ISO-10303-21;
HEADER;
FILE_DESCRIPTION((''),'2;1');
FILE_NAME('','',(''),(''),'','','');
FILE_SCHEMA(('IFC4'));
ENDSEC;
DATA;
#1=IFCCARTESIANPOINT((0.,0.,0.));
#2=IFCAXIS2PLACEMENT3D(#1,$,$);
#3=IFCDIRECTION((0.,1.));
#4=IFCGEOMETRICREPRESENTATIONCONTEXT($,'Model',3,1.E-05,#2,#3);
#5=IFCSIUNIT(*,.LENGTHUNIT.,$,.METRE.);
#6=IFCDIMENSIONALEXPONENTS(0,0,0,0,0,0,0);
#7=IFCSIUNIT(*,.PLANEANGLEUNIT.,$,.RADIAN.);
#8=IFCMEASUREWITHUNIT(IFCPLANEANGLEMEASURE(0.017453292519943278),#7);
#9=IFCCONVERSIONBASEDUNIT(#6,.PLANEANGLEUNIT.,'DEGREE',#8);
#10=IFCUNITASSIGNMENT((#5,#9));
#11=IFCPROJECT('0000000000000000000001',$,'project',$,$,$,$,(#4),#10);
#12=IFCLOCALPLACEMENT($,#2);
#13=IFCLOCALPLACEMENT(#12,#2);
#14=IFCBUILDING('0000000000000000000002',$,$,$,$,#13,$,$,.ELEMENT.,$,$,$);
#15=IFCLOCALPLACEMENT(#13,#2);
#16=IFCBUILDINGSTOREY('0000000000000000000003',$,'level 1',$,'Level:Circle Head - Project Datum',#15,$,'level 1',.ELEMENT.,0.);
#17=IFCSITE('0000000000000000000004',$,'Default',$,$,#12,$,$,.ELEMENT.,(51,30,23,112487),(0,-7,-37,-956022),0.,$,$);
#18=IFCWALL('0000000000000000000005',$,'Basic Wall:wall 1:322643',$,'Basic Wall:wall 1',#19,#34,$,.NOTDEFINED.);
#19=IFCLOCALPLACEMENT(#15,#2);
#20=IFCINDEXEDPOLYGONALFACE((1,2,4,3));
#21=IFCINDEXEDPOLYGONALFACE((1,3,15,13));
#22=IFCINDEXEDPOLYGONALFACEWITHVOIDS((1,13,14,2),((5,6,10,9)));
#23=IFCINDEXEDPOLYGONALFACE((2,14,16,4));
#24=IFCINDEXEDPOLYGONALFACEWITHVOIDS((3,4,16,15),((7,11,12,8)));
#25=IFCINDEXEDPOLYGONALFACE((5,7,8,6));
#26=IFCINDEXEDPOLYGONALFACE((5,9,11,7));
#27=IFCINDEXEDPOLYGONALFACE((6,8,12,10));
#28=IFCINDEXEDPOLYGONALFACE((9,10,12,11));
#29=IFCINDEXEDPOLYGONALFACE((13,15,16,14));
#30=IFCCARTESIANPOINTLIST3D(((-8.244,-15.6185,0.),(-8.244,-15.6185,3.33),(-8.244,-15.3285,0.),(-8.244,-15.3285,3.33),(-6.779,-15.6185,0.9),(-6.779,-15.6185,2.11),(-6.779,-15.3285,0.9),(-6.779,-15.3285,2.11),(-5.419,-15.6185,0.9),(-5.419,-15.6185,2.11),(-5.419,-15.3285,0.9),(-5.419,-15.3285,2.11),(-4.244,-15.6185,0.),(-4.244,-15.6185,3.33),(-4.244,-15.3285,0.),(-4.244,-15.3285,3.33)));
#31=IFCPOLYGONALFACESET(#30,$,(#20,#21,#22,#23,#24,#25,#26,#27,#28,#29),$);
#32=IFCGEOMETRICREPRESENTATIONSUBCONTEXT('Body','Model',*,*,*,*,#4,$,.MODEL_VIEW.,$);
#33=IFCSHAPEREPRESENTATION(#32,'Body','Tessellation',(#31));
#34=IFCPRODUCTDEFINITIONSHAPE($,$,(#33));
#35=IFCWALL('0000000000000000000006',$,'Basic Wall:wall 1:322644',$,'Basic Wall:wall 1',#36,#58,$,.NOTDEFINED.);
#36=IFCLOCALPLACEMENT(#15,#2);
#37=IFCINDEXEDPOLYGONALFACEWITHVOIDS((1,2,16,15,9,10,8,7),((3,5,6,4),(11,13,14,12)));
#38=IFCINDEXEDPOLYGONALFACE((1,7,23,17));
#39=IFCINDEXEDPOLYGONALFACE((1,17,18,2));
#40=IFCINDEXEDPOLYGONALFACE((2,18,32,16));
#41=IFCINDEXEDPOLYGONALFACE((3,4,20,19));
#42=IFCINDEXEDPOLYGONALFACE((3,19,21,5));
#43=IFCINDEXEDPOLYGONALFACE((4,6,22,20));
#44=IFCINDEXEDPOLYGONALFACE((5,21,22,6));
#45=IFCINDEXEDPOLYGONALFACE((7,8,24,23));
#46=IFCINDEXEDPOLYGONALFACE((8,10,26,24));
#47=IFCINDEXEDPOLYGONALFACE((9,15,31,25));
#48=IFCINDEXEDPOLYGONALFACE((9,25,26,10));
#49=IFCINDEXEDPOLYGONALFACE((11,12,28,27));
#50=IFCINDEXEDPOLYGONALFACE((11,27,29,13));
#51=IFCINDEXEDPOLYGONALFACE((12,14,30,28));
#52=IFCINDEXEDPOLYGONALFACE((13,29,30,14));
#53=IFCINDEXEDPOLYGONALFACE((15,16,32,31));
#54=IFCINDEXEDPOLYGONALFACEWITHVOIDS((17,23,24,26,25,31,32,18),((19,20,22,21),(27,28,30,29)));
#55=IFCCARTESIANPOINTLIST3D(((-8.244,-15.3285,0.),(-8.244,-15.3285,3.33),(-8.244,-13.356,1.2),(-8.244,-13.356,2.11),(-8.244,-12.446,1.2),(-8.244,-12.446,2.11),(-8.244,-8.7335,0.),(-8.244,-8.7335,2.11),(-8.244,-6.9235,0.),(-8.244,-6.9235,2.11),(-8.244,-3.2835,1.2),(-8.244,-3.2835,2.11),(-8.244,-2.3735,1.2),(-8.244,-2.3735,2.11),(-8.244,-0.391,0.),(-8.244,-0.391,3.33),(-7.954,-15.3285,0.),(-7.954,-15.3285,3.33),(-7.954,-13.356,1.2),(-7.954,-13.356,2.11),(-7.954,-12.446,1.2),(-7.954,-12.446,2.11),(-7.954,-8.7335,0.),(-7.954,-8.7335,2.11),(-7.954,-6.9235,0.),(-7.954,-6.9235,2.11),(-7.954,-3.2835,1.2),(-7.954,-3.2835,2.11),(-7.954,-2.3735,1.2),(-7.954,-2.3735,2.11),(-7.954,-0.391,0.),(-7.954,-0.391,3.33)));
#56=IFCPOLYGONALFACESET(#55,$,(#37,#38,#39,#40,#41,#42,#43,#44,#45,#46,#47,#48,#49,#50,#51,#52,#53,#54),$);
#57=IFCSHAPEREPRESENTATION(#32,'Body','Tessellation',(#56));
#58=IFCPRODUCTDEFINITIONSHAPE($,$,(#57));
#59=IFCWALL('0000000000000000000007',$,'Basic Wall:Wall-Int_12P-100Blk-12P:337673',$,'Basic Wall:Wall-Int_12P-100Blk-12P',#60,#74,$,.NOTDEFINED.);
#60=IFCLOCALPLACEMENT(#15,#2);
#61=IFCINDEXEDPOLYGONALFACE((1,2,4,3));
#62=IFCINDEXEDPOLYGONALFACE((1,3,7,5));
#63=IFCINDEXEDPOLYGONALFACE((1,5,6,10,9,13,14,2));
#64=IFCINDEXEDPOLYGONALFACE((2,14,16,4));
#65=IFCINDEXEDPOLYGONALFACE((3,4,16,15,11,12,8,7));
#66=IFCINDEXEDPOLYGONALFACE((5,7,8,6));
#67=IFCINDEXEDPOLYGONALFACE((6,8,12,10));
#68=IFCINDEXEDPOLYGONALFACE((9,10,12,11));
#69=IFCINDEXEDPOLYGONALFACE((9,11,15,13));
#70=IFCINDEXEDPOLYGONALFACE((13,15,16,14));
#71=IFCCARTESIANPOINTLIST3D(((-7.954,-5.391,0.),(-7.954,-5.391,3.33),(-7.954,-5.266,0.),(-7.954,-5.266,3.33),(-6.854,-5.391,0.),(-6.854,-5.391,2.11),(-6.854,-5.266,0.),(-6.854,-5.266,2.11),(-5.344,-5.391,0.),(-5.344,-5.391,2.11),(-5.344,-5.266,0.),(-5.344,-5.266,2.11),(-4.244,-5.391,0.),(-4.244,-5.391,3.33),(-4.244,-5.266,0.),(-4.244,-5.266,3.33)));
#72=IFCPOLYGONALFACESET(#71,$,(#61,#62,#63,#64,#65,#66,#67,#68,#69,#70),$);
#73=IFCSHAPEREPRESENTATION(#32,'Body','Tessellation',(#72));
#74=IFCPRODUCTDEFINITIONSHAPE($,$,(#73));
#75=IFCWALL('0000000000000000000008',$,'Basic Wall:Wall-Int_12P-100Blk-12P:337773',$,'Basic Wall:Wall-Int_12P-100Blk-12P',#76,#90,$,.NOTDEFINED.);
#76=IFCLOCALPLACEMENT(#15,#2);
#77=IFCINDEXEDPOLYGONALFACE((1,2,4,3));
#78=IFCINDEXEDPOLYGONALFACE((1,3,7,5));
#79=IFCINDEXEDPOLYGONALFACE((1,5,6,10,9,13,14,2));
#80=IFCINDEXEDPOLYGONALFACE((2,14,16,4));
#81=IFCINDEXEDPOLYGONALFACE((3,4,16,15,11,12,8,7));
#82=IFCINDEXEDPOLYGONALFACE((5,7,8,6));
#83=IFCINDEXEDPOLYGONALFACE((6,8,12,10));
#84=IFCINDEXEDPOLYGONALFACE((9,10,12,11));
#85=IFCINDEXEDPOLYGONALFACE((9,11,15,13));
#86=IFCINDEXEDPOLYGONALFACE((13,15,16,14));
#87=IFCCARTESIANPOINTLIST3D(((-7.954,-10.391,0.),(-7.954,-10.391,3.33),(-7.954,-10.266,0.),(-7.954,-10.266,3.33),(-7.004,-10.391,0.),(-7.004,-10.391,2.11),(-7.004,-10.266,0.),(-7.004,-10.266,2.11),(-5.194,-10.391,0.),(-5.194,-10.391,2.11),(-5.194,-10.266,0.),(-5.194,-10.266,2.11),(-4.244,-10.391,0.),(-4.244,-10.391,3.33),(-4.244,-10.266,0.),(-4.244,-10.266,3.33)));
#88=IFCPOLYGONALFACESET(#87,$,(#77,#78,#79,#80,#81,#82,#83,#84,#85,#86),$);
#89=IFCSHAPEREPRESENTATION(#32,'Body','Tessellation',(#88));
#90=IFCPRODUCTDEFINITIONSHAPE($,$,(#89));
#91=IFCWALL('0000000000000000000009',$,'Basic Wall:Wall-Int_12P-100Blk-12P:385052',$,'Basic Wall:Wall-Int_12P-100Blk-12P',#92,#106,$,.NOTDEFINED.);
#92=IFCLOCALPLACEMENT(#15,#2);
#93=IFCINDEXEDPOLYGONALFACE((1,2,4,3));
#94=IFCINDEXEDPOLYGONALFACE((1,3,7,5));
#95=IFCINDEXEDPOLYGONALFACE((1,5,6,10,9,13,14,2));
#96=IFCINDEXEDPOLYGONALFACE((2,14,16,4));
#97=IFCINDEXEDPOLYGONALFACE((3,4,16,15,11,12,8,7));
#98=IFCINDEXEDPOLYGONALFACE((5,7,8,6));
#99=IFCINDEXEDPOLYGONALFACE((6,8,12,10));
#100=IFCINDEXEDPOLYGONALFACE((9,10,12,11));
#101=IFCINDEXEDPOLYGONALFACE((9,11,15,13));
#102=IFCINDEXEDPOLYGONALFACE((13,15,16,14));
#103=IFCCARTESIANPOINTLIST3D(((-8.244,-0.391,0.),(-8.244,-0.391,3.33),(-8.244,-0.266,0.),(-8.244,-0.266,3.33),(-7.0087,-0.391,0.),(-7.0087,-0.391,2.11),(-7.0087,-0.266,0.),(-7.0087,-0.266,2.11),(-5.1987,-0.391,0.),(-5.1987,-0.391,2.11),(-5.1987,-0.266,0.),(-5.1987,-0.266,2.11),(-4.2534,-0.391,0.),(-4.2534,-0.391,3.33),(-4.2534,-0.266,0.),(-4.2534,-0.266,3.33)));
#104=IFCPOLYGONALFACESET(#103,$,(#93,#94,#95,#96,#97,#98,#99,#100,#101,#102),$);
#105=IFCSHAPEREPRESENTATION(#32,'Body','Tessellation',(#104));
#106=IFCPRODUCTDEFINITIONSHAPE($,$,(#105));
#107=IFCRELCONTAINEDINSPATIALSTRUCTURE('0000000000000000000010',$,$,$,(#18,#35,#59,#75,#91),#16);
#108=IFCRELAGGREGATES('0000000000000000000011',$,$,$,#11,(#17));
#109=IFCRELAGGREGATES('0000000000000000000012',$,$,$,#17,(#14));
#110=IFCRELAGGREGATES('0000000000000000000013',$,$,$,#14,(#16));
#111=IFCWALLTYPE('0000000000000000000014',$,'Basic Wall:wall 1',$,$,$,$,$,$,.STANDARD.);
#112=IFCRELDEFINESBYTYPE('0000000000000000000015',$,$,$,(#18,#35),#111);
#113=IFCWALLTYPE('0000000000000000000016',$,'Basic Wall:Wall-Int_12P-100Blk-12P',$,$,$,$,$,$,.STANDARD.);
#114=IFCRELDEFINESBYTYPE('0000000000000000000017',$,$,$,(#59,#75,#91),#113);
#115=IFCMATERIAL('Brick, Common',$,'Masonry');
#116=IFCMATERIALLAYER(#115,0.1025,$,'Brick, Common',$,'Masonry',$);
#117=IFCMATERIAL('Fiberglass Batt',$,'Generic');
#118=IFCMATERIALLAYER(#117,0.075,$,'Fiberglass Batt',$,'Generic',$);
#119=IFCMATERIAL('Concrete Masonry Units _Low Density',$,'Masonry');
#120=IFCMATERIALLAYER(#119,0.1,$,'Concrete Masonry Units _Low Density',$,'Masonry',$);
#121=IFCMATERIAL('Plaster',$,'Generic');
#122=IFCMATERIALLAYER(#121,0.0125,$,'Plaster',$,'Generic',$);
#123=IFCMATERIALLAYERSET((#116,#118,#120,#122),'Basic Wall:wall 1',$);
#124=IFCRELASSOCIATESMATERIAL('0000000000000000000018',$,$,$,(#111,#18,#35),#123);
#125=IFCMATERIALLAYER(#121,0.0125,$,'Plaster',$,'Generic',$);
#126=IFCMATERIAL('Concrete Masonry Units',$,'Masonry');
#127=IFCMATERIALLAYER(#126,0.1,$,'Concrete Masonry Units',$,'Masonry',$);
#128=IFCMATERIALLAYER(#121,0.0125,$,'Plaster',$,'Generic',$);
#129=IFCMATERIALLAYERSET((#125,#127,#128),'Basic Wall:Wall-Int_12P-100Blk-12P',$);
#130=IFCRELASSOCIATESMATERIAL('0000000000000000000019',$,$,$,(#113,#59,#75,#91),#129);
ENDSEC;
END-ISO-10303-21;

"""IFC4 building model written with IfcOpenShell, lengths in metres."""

from ifc_helpers import new_model, entity, si_unit, converted_unit, direction, frame, frame_2d, origin, place, context, subcontext, project, spatial, polyline, rectangle, extrude, clip, bounded_halfspace, material, layer, layer_set, layer_usage, type_object, element, save


model = new_model("IFC4")

# Units and contexts
model_context = context("Model", 3, precision=1e-05, world=origin(), true_north=direction((0.0, 1.0)))
body_context = subcontext(model_context, "Body", "Model", "MODEL_VIEW")
ifc_project = project(units=[si_unit("LENGTHUNIT", "METRE"), converted_unit("PLANEANGLEUNIT", "DEGREE", entity("IfcPlaneAngleMeasure", 0.017453292519943278), si_unit("PLANEANGLEUNIT", "RADIAN"), dimensions=[0, 0, 0, 0, 0, 0, 0])], contexts=[model_context])

# Site, building, storey
site_placement = place(None, origin())
site = spatial("IfcSite", under=ifc_project, at=site_placement, Name="Default", CompositionType="ELEMENT", RefLatitude=(51, 30, 23, 112487), RefLongitude=(0, -7, -37, -956022), RefElevation=0.0)
building_placement = place(site_placement, origin())
building = spatial("IfcBuilding", under=site, at=building_placement, CompositionType="ELEMENT")
storey_placement = place(building_placement, origin())
storey = spatial("IfcBuildingStorey", under=building, at=storey_placement, Name="level 1", ObjectType="Level:Circle Head - Project Datum", LongName="level 1", CompositionType="ELEMENT", Elevation=0.0)

# Shared definitions
ifc_material_1 = material(Name="Brick, Common", Category="Masonry")
ifc_layer_1 = layer(ifc_material_1, 0.1025, Name="Brick, Common", Category="Masonry")
ifc_material_2 = material(Name="Fiberglass Batt", Category="Generic")
ifc_layer_2 = layer(ifc_material_2, 0.075, Name="Fiberglass Batt", Category="Generic")
ifc_material_3 = material(Name="Concrete Masonry Units _Low Density", Category="Masonry")
ifc_layer_3 = layer(ifc_material_3, 0.1, Name="Concrete Masonry Units _Low Density", Category="Masonry")
ifc_material_4 = material(Name="Plaster", Category="Generic")
ifc_layer_4 = layer(ifc_material_4, 0.0125, Name="Plaster", Category="Generic")
ifc_layer_set_1 = layer_set([ifc_layer_1, ifc_layer_2, ifc_layer_3, ifc_layer_4], Name="Basic Wall:wall 1")
wall_type_1 = type_object("IfcWallType", Name="Basic Wall:wall 1", PredefinedType="STANDARD", material=ifc_layer_set_1)

# Wall, opening
ifc_layer_usage_1 = layer_usage(ifc_layer_set_1, "AXIS2", "NEGATIVE", 0.145)
wall_1_placement = place(storey_placement, frame((-4.244, -15.4735, 0.0), z_axis=(0.0, 0.0, 1.0), x_axis=(-1.0, 0.0, 0.0)))
wall_1 = element("IfcWall", 1, at=wall_1_placement, inside=storey, type_object=wall_type_1, material=ifc_layer_usage_1, Name="Basic Wall:wall 1:322643", ObjectType="Basic Wall:wall 1", PredefinedType="NOTDEFINED", context=body_context, shape_type="Clipping", body=[
    clip(extrude(rectangle(XDim=4.0, YDim=0.29, at=frame_2d((2.0, 0.0), x_axis=(-1.0, 0.0))), origin(), (0.0, 0.0, 1.0), 3.33), bounded_halfspace(frame((0.0, -0.145, 3.33), z_axis=(0.0, 0.0, -1.0), x_axis=(0.0, -1.0, 0.0)), True, frame((0.0, -0.145, 3.33)), polyline([(0.0, 0.0), (3.71, 0.0), (4.0, 0.0), (4.0, 0.29), (0.0, 0.29), (0.0, 0.0)]))),
])
opening_1_placement = place(wall_1_placement, frame((1.175, -0.145, 0.9)))
element("IfcOpeningElement", 2, at=opening_1_placement, cuts=wall_1, PredefinedType="OPENING", context=body_context, shape_type="SweptSolid", body=[
    extrude(rectangle(XDim=1.21, YDim=1.36, at=frame_2d((0.605, 0.68), x_axis=(-1.0, 0.0))), frame((0.0, 0.0, 0.0), z_axis=(0.0, 1.0, 0.0), x_axis=(0.0, 0.0, 1.0)), (0.0, 0.0, 1.0), 0.29),
])

# Wall, openings
ifc_layer_usage_2 = layer_usage(ifc_layer_set_1, "AXIS2", "NEGATIVE", 0.145)
wall_2_placement = place(storey_placement, frame((-8.099, -15.3285, 0.0), z_axis=(0.0, 0.0, 1.0), x_axis=(0.0, 1.0, 0.0)))
wall_2 = element("IfcWall", 3, at=wall_2_placement, inside=storey, type_object=wall_type_1, material=ifc_layer_usage_2, Name="Basic Wall:wall 1:322644", ObjectType="Basic Wall:wall 1", PredefinedType="NOTDEFINED", context=body_context, shape_type="Clipping", body=[
    clip(extrude(rectangle(XDim=14.9375, YDim=0.29, at=frame_2d((7.4688, 0.0), x_axis=(1.0, 0.0))), origin(), (0.0, 0.0, 1.0), 3.33), bounded_halfspace(frame((0.0, -0.145, 3.33), z_axis=(0.0, 0.0, -1.0), x_axis=(1.0, 0.0, 0.0)), True, frame((0.0, -0.145, 3.33)), polyline([(0.0, 0.0), (4.9375, 0.0), (5.0625, 0.0), (9.9375, 0.0), (10.0625, 0.0), (14.9375, 0.0), (14.9375, 0.29), (0.0, 0.29), (0.0, 0.0)]))),
])
opening_2_placement = place(wall_2_placement, frame((8.405, 0.145, 0.0)))
element("IfcOpeningElement", 4, at=opening_2_placement, cuts=wall_2, PredefinedType="OPENING", context=body_context, shape_type="SweptSolid", body=[
    extrude(rectangle(XDim=2.11, YDim=1.81, at=frame_2d((1.055, 0.905), x_axis=(-1.0, 0.0))), frame((0.0, 0.0, 0.0), z_axis=(0.0, -1.0, 0.0), x_axis=(0.0, 0.0, 1.0)), (0.0, 0.0, 1.0), 0.29),
])
opening_3_placement = place(wall_2_placement, frame((1.9725, -0.145, 1.2)))
element("IfcOpeningElement", 5, at=opening_3_placement, cuts=wall_2, PredefinedType="OPENING", context=body_context, shape_type="SweptSolid", body=[
    extrude(rectangle(XDim=0.91, YDim=0.91, at=frame_2d((0.455, 0.455), x_axis=(-1.0, 0.0))), frame((0.0, 0.0, 0.0), z_axis=(0.0, 1.0, 0.0), x_axis=(0.0, 0.0, 1.0)), (0.0, 0.0, 1.0), 0.29),
])
opening_4_placement = place(wall_2_placement, frame((12.045, -0.145, 1.2)))
element("IfcOpeningElement", 6, at=opening_4_placement, cuts=wall_2, PredefinedType="OPENING", context=body_context, shape_type="SweptSolid", body=[
    extrude(rectangle(XDim=0.91, YDim=0.91, at=frame_2d((0.455, 0.455), x_axis=(-1.0, 0.0))), frame((0.0, 0.0, 0.0), z_axis=(0.0, 1.0, 0.0), x_axis=(0.0, 0.0, 1.0)), (0.0, 0.0, 1.0), 0.29),
])

# Walls, openings
ifc_layer_5 = layer(ifc_material_4, 0.0125, Name="Plaster", Category="Generic")
ifc_material_5 = material(Name="Concrete Masonry Units", Category="Masonry")
ifc_layer_6 = layer(ifc_material_5, 0.1, Name="Concrete Masonry Units", Category="Masonry")
ifc_layer_7 = layer(ifc_material_4, 0.0125, Name="Plaster", Category="Generic")
ifc_layer_set_2 = layer_set([ifc_layer_5, ifc_layer_6, ifc_layer_7], Name="Basic Wall:Wall-Int_12P-100Blk-12P")
ifc_layer_usage_3 = layer_usage(ifc_layer_set_2, "AXIS2", "NEGATIVE", 0.0625)
wall_type_2 = type_object("IfcWallType", Name="Basic Wall:Wall-Int_12P-100Blk-12P", PredefinedType="STANDARD", material=ifc_layer_set_2)
wall_3_placement = place(storey_placement, frame((-7.954, -5.3285, 0.0)))
wall_3 = element("IfcWall", 7, at=wall_3_placement, inside=storey, type_object=wall_type_2, material=ifc_layer_usage_3, Name="Basic Wall:Wall-Int_12P-100Blk-12P:337673", ObjectType="Basic Wall:Wall-Int_12P-100Blk-12P", PredefinedType="NOTDEFINED", context=body_context, shape_type="Clipping", body=[
    clip(extrude(rectangle(XDim=3.71, YDim=0.125, at=frame_2d((1.855, 0.0), x_axis=(1.0, 0.0))), origin(), (0.0, 0.0, 1.0), 3.33), bounded_halfspace(frame((0.0, -0.0625, 3.33), z_axis=(0.0, 0.0, -1.0), x_axis=(0.0, 1.0, 0.0)), True, frame((0.0, -0.0625, 3.33)), polyline([(0.0, 0.0), (3.71, 0.0), (3.71, 0.125), (0.0, 0.125), (0.0, 0.0)]))),
])
opening_5_placement = place(wall_3_placement, frame((1.1, -0.0625, 0.0)))
element("IfcOpeningElement", 8, at=opening_5_placement, cuts=wall_3, PredefinedType="OPENING", context=body_context, shape_type="SweptSolid", body=[
    extrude(rectangle(XDim=2.11, YDim=1.51, at=frame_2d((1.055, 0.755), x_axis=(-1.0, 0.0))), frame((0.0, 0.0, 0.0), z_axis=(0.0, 1.0, 0.0), x_axis=(0.0, 0.0, 1.0)), (0.0, 0.0, 1.0), 0.125),
])
ifc_layer_usage_4 = layer_usage(ifc_layer_set_2, "AXIS2", "NEGATIVE", 0.0625)
wall_4_placement = place(storey_placement, frame((-7.954, -10.3285, 0.0)))
wall_4 = element("IfcWall", 9, at=wall_4_placement, inside=storey, type_object=wall_type_2, material=ifc_layer_usage_4, Name="Basic Wall:Wall-Int_12P-100Blk-12P:337773", ObjectType="Basic Wall:Wall-Int_12P-100Blk-12P", PredefinedType="NOTDEFINED", context=body_context, shape_type="Clipping", body=[
    clip(extrude(rectangle(XDim=3.71, YDim=0.125, at=frame_2d((1.855, 0.0), x_axis=(-1.0, 0.0))), origin(), (0.0, 0.0, 1.0), 3.33), bounded_halfspace(frame((0.0, -0.0625, 3.33), z_axis=(0.0, 0.0, -1.0), x_axis=(0.0, 1.0, 0.0)), True, frame((0.0, -0.0625, 3.33)), polyline([(0.0, 0.0), (3.71, 0.0), (3.71, 0.125), (0.0, 0.125), (0.0, 0.0)]))),
])
opening_6_placement = place(wall_4_placement, frame((0.95, -0.0625, 0.0)))
element("IfcOpeningElement", 10, at=opening_6_placement, cuts=wall_4, PredefinedType="OPENING", context=body_context, shape_type="SweptSolid", body=[
    extrude(rectangle(XDim=2.11, YDim=1.81, at=frame_2d((1.055, 0.905), x_axis=(-1.0, 0.0))), frame((0.0, 0.0, 0.0), z_axis=(0.0, 1.0, 0.0), x_axis=(0.0, 0.0, 1.0)), (0.0, 0.0, 1.0), 0.125),
])

# Wall, openings
ifc_layer_usage_5 = layer_usage(ifc_layer_set_2, "AXIS2", "NEGATIVE", 0.0625)
wall_5_placement = place(storey_placement, frame((-4.2534, -0.3285, 0.0), z_axis=(0.0, 0.0, 1.0), x_axis=(-1.0, 0.0, 0.0)))
wall_5 = element("IfcWall", 11, at=wall_5_placement, inside=storey, type_object=wall_type_2, material=ifc_layer_usage_5, Name="Basic Wall:Wall-Int_12P-100Blk-12P:385052", ObjectType="Basic Wall:Wall-Int_12P-100Blk-12P", PredefinedType="NOTDEFINED", context=body_context, shape_type="Clipping", body=[
    clip(extrude(rectangle(XDim=3.9906, YDim=0.125, at=frame_2d((1.9953, 0.0), x_axis=(-1.0, 0.0))), origin(), (0.0, 0.0, 1.0), 3.33), bounded_halfspace(frame((0.0, -0.0625, 3.33), z_axis=(0.0, 0.0, -1.0), x_axis=(0.0, -1.0, 0.0)), True, frame((0.0, -0.0625, 3.33)), polyline([(0.0, 0.0), (3.7006, 0.0), (3.9906, 0.0), (3.9906, 0.125), (3.7006, 0.125), (0.0, 0.125), (0.0, 0.0)]))),
])
opening_7_placement = place(wall_5_placement, frame((2.7553, 0.0625, 0.0)))
element("IfcOpeningElement", 12, at=opening_7_placement, cuts=wall_5, PredefinedType="OPENING", context=body_context, shape_type="SweptSolid", body=[
    extrude(rectangle(XDim=2.11, YDim=1.81, at=frame_2d((1.055, 0.905), x_axis=(-1.0, 0.0))), frame((0.0, 0.0, 0.0), z_axis=(0.0, -1.0, 0.0), x_axis=(0.0, 0.0, 1.0)), (0.0, 0.0, 1.0), 0.125),
])
opening_8_placement = place(wall_5_placement, frame((-4.2534, -0.3285, 0.0), z_axis=(0.0, 0.0, 1.0), x_axis=(-1.0, 0.0, 0.0)))
element("IfcOpeningElement", 13, at=opening_8_placement, cuts=wall_5, PredefinedType="OPENING", context=body_context, shape_type="SweptSolid", body=[
    extrude(rectangle(XDim=2.11, YDim=1.81, at=frame_2d((0.0, 0.0), x_axis=(0.0, 1.0))), frame((-6.1037, 1.258, 1.055), z_axis=(0.0, -1.0, 0.0), x_axis=(-1.0, 0.0, 0.0)), (0.0, 0.0, 1.0), 3.048),
])

save(model, "model.ifc")
